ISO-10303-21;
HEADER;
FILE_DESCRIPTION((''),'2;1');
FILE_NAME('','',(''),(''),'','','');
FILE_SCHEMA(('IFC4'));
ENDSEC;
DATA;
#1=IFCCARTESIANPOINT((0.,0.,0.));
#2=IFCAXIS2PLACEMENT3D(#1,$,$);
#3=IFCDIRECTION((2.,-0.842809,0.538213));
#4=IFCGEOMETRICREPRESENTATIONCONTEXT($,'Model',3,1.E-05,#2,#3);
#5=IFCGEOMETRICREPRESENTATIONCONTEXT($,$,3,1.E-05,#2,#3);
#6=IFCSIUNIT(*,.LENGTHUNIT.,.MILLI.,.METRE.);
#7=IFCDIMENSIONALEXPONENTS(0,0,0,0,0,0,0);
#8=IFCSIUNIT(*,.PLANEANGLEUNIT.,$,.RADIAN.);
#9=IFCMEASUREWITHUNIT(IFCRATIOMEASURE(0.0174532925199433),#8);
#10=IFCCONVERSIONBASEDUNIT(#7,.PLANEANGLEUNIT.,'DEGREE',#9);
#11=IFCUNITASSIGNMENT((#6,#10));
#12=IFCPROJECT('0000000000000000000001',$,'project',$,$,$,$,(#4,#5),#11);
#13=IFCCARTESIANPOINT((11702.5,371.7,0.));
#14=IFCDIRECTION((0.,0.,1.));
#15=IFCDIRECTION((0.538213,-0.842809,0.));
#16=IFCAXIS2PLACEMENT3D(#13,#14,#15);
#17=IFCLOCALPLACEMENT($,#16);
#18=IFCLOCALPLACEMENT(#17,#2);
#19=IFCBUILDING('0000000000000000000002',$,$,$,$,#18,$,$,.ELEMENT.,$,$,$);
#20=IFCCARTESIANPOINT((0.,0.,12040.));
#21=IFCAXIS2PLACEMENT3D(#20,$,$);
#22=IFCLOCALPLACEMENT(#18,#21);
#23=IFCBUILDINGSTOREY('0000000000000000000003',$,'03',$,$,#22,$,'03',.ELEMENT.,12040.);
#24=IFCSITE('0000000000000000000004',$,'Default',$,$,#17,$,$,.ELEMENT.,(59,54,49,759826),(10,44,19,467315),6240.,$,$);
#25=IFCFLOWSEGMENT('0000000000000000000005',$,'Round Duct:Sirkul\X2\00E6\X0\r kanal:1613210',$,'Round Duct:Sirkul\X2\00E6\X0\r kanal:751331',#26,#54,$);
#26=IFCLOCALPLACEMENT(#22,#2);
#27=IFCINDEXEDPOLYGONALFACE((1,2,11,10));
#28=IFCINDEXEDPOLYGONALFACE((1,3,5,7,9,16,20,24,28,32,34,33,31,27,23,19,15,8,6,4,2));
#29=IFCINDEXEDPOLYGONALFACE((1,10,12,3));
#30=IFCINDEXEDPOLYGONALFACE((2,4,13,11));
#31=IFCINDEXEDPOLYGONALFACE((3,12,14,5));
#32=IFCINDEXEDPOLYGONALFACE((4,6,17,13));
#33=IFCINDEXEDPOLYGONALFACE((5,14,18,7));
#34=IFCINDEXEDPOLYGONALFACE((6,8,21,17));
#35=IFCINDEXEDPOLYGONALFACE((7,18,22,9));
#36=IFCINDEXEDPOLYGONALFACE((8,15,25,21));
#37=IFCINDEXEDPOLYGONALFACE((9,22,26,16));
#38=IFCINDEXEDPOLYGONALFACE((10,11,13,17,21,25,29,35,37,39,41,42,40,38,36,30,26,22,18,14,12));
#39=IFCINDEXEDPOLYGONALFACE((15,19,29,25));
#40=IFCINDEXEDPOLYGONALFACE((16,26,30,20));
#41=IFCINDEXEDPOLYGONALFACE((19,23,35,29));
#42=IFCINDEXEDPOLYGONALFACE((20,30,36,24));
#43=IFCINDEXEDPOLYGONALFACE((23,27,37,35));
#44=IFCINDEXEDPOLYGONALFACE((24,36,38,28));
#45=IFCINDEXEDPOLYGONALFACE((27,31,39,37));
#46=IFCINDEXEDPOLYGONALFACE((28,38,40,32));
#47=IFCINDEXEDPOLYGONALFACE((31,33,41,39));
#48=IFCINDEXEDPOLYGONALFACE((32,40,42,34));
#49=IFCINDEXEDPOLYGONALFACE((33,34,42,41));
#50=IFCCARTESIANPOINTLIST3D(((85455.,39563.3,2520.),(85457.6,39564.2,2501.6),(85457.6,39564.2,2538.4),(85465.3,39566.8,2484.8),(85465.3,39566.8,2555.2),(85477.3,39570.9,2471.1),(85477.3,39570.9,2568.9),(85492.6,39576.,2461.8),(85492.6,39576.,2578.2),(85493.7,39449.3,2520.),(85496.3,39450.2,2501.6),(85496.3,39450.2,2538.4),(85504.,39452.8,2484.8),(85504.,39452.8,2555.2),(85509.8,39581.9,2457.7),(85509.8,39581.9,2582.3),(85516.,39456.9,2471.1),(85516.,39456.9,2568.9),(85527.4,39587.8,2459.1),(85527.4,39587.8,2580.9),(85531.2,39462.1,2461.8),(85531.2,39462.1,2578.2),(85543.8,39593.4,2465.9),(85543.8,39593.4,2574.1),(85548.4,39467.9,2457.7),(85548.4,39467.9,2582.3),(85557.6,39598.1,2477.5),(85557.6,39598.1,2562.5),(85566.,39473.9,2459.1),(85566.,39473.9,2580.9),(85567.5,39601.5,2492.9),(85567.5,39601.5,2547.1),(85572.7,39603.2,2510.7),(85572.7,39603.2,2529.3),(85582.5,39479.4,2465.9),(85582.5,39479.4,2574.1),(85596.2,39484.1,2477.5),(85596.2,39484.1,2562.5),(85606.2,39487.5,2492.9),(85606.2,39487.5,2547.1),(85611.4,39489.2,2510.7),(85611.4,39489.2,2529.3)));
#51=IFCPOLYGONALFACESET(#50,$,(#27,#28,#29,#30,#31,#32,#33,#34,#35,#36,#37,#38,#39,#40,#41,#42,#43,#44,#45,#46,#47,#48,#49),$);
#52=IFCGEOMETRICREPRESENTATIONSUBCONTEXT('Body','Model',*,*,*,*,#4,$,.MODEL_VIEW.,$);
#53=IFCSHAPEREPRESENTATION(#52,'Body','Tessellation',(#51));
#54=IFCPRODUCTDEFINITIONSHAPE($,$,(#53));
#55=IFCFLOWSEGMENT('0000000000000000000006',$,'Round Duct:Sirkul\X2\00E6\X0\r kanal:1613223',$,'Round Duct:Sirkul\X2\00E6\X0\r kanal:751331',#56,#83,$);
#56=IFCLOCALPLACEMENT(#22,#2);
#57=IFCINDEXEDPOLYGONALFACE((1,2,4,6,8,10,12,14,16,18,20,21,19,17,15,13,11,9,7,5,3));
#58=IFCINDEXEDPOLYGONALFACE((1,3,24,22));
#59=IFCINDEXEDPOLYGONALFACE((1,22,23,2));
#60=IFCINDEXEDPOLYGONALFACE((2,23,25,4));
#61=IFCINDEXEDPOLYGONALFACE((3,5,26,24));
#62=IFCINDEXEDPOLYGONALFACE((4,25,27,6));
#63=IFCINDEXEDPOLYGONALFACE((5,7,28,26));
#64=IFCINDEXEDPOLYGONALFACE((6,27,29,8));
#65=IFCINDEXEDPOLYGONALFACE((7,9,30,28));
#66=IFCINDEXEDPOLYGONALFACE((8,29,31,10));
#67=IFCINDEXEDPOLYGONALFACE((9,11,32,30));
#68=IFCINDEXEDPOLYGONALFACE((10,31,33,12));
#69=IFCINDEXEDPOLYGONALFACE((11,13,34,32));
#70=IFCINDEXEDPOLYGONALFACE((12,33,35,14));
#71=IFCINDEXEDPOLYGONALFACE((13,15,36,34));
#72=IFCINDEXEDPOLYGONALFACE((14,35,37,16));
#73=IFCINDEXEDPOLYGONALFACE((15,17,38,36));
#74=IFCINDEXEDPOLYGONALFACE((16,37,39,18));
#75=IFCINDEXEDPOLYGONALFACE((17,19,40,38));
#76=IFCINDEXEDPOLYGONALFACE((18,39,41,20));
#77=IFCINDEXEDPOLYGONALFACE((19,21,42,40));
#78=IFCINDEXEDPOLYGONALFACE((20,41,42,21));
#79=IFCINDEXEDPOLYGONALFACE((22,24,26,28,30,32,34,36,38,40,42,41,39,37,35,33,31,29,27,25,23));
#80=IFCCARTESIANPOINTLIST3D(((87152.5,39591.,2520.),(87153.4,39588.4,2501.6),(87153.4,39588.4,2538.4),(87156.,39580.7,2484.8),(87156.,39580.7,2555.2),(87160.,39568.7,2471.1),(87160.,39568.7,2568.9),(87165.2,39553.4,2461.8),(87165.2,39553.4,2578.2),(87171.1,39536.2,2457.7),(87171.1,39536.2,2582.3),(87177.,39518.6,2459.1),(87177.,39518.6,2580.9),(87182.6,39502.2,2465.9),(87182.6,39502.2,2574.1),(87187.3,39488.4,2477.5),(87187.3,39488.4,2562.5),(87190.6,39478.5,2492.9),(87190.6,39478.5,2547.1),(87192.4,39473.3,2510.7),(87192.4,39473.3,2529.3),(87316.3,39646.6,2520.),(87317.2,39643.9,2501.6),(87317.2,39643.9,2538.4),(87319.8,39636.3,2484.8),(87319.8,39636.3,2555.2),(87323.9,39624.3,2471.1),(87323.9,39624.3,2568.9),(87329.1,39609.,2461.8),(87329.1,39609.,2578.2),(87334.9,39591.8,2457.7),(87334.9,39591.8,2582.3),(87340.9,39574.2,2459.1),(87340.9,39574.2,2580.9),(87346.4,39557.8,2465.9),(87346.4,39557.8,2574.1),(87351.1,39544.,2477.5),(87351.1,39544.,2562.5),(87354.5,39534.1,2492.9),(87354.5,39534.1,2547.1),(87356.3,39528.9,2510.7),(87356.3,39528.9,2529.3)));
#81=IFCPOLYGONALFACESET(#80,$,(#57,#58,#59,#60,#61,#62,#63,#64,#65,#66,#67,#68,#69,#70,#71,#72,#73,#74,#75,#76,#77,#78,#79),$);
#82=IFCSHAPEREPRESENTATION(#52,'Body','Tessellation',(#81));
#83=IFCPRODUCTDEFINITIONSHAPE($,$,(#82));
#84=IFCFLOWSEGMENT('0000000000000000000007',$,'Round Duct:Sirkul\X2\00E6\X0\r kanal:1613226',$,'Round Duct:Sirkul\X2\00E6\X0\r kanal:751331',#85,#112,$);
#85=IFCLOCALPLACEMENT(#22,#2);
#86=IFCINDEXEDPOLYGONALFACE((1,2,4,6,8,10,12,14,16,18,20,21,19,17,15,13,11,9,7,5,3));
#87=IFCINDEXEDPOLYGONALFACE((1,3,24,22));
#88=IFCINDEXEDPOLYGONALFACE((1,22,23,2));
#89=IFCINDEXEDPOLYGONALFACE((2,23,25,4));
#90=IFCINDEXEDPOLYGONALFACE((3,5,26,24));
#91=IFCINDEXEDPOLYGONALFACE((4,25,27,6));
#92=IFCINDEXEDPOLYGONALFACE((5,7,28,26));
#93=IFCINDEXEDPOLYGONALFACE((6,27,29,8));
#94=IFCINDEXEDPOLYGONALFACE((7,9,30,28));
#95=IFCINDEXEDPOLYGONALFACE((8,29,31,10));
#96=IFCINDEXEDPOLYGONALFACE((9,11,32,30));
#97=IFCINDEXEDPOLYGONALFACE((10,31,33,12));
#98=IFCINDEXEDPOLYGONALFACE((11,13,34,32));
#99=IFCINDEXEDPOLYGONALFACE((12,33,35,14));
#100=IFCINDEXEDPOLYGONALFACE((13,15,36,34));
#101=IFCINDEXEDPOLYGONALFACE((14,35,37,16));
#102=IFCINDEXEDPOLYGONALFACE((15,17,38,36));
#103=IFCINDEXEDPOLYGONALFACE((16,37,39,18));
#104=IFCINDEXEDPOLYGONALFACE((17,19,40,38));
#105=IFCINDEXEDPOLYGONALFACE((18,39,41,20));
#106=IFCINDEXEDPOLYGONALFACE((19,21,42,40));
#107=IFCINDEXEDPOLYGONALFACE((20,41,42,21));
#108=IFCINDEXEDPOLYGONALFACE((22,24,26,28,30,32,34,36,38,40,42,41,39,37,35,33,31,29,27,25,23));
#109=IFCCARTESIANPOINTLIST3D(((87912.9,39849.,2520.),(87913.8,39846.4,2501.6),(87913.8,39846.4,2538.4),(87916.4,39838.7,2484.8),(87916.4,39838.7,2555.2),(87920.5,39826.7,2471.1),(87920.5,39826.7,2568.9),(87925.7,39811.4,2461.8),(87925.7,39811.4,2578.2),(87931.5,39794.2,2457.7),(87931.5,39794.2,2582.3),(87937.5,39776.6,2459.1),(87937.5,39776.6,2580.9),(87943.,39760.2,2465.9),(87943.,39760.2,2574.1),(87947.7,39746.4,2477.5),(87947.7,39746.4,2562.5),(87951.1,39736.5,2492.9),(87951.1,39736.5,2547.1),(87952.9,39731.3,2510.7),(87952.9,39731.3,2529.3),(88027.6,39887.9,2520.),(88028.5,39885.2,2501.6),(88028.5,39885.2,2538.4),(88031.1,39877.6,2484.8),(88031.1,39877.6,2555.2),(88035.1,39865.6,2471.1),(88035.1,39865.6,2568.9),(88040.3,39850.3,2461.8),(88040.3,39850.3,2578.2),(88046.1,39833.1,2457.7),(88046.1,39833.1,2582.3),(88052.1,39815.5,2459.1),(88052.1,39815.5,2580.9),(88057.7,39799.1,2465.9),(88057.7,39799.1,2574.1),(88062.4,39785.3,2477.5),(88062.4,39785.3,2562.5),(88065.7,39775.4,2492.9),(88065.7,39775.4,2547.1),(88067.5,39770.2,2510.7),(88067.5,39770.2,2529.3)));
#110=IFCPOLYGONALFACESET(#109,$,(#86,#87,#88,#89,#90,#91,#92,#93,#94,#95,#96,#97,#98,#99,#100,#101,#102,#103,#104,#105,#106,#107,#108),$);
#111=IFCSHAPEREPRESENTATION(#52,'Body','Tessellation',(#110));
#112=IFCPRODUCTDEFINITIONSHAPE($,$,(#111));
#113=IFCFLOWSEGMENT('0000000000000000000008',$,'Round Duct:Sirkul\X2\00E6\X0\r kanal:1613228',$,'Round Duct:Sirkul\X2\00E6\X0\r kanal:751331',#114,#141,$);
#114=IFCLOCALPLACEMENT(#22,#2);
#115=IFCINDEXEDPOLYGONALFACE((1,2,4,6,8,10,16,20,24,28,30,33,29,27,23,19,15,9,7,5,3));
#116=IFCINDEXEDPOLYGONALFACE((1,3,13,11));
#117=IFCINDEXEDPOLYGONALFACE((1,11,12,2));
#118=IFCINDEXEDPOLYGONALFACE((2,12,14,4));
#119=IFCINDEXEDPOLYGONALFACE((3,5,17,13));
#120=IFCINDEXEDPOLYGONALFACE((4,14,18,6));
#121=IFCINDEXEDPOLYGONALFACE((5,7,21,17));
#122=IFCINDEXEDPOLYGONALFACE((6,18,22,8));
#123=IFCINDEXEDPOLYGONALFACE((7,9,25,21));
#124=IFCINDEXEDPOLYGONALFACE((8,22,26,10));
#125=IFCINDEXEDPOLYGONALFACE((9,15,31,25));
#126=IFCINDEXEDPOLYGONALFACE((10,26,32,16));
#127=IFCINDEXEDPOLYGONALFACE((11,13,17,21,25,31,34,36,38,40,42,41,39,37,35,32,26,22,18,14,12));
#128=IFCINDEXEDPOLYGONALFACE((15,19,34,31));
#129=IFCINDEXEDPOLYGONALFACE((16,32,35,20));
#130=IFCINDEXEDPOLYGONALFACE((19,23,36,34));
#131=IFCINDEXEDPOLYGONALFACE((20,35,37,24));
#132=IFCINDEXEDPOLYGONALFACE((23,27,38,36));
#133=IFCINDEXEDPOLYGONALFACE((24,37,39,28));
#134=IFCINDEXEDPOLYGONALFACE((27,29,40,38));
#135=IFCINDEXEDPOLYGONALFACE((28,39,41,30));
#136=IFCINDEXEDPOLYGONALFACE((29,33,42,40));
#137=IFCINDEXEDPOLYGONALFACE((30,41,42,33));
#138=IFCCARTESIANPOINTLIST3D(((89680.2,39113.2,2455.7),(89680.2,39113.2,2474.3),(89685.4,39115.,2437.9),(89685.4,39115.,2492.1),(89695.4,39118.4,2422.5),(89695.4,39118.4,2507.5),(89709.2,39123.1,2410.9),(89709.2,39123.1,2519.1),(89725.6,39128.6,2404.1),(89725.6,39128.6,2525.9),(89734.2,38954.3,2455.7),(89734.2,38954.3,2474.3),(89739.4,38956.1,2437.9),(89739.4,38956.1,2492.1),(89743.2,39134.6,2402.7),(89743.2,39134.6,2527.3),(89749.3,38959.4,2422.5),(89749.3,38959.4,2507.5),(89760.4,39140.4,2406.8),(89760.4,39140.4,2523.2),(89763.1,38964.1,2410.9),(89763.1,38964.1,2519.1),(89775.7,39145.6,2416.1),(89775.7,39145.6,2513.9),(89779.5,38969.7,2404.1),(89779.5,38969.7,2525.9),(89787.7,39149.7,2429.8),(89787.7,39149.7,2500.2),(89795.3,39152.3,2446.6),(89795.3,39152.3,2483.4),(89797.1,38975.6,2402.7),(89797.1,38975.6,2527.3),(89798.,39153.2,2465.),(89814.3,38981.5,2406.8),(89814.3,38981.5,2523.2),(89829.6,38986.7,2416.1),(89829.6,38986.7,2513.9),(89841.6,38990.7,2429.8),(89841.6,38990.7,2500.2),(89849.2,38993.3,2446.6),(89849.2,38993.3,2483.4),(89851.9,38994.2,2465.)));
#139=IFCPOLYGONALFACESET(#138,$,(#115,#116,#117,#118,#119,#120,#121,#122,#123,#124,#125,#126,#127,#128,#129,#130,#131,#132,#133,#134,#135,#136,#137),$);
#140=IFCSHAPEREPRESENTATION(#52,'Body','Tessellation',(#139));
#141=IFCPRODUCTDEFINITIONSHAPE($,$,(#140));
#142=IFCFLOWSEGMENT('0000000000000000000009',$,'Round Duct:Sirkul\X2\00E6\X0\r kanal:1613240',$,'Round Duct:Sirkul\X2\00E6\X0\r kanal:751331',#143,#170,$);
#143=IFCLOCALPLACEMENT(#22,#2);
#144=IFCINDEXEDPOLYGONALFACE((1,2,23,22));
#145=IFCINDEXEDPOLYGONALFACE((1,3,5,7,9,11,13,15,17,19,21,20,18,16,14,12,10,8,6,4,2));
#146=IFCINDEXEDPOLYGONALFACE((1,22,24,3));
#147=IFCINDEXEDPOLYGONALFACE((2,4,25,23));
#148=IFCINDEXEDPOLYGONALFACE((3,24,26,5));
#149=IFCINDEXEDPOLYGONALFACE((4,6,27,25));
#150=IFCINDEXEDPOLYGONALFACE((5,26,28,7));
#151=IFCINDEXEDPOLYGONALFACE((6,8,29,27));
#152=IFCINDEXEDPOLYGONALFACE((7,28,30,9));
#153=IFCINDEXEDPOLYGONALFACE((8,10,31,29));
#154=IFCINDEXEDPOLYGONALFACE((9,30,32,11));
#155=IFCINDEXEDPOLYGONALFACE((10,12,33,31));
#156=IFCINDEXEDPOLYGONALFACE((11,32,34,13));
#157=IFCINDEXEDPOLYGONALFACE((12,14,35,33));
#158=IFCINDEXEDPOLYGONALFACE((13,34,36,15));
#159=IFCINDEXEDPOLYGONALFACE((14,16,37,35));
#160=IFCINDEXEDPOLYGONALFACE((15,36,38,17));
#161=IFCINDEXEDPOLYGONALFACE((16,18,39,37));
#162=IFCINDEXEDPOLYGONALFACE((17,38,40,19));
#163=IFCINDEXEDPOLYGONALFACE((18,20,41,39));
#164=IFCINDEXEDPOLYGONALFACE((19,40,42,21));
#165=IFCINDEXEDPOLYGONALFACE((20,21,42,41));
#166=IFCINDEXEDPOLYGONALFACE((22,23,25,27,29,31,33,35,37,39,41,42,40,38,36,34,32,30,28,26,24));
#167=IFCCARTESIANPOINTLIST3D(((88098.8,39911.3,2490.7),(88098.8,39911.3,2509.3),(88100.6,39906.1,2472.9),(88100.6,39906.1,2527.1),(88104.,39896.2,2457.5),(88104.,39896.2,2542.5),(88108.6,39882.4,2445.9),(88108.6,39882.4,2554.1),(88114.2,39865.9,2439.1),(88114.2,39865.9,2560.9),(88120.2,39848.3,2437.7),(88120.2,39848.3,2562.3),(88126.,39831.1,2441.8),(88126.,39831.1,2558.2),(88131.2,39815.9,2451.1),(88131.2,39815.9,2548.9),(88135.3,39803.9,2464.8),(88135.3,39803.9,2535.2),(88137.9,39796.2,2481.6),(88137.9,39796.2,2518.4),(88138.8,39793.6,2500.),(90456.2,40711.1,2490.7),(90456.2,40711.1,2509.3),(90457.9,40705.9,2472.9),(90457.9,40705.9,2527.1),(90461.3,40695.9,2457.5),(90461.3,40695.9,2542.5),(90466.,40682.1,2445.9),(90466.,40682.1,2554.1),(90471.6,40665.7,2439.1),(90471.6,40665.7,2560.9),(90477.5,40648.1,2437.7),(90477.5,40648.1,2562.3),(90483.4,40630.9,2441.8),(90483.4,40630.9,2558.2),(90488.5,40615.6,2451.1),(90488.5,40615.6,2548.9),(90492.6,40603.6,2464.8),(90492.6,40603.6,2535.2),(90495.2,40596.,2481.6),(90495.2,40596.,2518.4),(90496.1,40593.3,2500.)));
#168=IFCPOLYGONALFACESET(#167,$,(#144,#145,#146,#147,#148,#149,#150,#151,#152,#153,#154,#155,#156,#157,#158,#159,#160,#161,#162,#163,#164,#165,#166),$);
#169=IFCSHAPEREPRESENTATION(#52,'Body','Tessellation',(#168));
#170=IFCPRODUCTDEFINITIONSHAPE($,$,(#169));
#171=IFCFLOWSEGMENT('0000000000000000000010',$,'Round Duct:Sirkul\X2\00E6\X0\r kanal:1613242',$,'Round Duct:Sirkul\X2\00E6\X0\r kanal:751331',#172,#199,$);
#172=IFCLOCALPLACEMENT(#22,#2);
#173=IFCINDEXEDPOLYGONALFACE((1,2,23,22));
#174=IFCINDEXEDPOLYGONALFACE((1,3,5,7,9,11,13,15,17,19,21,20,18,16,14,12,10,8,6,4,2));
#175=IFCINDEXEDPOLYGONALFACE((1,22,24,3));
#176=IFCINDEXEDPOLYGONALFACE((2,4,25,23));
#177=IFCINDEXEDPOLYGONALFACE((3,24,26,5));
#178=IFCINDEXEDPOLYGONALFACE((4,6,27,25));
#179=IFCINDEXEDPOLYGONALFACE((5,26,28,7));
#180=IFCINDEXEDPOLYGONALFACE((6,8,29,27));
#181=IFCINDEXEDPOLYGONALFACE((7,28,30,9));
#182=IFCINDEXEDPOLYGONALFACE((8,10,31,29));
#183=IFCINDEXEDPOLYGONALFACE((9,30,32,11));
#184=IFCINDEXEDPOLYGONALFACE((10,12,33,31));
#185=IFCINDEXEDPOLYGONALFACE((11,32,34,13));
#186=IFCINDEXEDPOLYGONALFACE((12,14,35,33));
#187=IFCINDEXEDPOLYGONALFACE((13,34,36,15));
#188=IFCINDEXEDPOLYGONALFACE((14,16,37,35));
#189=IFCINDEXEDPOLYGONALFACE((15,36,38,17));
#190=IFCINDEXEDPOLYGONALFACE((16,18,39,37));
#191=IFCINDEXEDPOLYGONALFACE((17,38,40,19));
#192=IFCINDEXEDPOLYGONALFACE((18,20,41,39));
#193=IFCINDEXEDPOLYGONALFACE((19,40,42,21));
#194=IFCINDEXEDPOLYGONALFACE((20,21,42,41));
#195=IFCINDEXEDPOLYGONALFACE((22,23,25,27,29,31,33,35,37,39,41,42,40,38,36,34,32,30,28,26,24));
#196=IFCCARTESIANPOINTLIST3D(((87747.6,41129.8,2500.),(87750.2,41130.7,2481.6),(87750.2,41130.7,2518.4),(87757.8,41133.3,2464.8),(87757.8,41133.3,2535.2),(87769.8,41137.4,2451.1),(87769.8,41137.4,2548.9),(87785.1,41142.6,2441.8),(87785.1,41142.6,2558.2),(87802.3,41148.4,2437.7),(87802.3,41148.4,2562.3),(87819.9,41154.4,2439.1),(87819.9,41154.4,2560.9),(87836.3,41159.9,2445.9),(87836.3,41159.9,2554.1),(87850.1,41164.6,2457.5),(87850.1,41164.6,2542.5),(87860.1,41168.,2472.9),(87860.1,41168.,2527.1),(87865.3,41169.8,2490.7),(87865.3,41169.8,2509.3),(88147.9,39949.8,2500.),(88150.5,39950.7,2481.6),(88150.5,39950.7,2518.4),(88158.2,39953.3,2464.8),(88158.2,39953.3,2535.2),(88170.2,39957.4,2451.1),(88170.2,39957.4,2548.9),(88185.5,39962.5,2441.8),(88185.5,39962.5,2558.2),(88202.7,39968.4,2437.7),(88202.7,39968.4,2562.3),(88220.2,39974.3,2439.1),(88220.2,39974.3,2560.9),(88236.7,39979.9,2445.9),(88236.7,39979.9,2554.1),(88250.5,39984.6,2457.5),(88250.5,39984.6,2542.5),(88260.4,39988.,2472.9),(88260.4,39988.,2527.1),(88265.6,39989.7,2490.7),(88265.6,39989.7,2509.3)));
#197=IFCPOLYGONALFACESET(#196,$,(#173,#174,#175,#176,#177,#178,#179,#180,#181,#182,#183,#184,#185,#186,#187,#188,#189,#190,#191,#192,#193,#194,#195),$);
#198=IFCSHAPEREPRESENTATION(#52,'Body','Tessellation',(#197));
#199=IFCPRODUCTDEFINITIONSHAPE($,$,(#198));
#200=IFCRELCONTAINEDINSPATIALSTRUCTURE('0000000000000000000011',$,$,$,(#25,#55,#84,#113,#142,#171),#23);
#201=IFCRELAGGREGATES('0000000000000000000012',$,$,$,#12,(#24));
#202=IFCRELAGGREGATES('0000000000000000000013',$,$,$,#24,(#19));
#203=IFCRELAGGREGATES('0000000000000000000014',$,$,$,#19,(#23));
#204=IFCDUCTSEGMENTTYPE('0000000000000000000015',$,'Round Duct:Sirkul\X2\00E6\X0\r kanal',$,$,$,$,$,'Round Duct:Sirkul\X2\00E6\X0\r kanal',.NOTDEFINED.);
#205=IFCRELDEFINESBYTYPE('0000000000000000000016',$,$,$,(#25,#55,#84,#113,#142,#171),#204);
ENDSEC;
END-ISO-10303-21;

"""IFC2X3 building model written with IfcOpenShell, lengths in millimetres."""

from ifc_helpers import new_model, entity, si_unit, converted_unit, direction, frame, frame_2d, origin, origin_2d_with_axis, place, context, subcontext, project, spatial, circle, extrude, type_object, element, save


model = new_model("IFC2X3")

# Units and contexts
model_context = context("Model", 3, precision=1e-05, world=origin(), true_north=direction((2.0, -0.842809, 0.538213)))
context_of_model = context(None, 3, precision=1e-05, world=origin(), true_north=direction((2.0, -0.842809, 0.538213)))
body_context = subcontext(model_context, "Body", "Model", "MODEL_VIEW")
ifc_project = project(units=[si_unit("LENGTHUNIT", "METRE", prefix="MILLI"), converted_unit("PLANEANGLEUNIT", "DEGREE", entity("IfcRatioMeasure", 0.0174532925199433), si_unit("PLANEANGLEUNIT", "RADIAN"), dimensions=[0, 0, 0, 0, 0, 0, 0])], contexts=[model_context, context_of_model])

# Site, building, storey
site_placement = place(None, frame((11702.5, 371.7, 0.0), z_axis=(0.0, 0.0, 1.0), x_axis=(0.538213, -0.842809, 0.0)))
site = spatial("IfcSite", under=ifc_project, at=site_placement, Name="Default", CompositionType="ELEMENT", RefLatitude=(59, 54, 49, 759826), RefLongitude=(10, 44, 19, 467315), RefElevation=6240.0)
building_placement = place(site_placement, origin())
building = spatial("IfcBuilding", under=site, at=building_placement, CompositionType="ELEMENT")
storey_placement = place(building_placement, frame((0.0, 0.0, 12040.0)))
storey = spatial("IfcBuildingStorey", under=building, at=storey_placement, Name="03", LongName="03", CompositionType="ELEMENT", Elevation=12040.0)

# Flow segments
duct_segment_type = type_object("IfcDuctSegmentType", Name="Round Duct:Sirkulær kanal", ElementType="Round Duct:Sirkulær kanal", PredefinedType="NOTDEFINED")
flow_segment_1_placement = place(storey_placement, origin())
element("IfcFlowSegment", 1, at=flow_segment_1_placement, inside=storey, type_object=duct_segment_type, Name="Round Duct:Sirkulær kanal:1613210", ObjectType="Round Duct:Sirkulær kanal:751331", context=body_context, shape_type="SweptSolid", body=[
    extrude(circle(Radius=62.5, at=frame_2d((0.0, 0.0), x_axis=(1.0, 0.0))), frame((85552.9, 39469.4, 2520.0), z_axis=(-0.321274, 0.946986, 0.0), x_axis=(-0.946986, -0.321274, 0.0)), (0.0, 0.0, 1.0), 120.4),
])
flow_segment_2_placement = place(storey_placement, origin())
element("IfcFlowSegment", 2, at=flow_segment_2_placement, inside=storey, type_object=duct_segment_type, Name="Round Duct:Sirkulær kanal:1613223", ObjectType="Round Duct:Sirkulær kanal:751331", context=body_context, shape_type="SweptSolid", body=[
    extrude(circle(Radius=62.5, at=origin_2d_with_axis()), frame((87172.6, 39531.8, 2520.0), z_axis=(0.946986, 0.321274, 0.0), x_axis=(-0.321274, 0.946986, 0.0)), (0.0, 0.0, 1.0), 173.0),
])
flow_segment_3_placement = place(storey_placement, origin())
element("IfcFlowSegment", 3, at=flow_segment_3_placement, inside=storey, type_object=duct_segment_type, Name="Round Duct:Sirkulær kanal:1613226", ObjectType="Round Duct:Sirkulær kanal:751331", context=body_context, shape_type="SweptSolid", body=[
    extrude(circle(Radius=62.5, at=origin_2d_with_axis()), frame((87933.0, 39789.8, 2520.0), z_axis=(0.946986, 0.321274, 0.0), x_axis=(-0.321274, 0.946986, 0.0)), (0.0, 0.0, 1.0), 121.1),
])
flow_segment_4_placement = place(storey_placement, origin())
element("IfcFlowSegment", 4, at=flow_segment_4_placement, inside=storey, type_object=duct_segment_type, Name="Round Duct:Sirkulær kanal:1613228", ObjectType="Round Duct:Sirkulær kanal:751331", context=body_context, shape_type="SweptSolid", body=[
    extrude(circle(Radius=62.5, at=origin_2d_with_axis()), frame((89792.7, 38974.1, 2465.0), z_axis=(-0.321246, 0.946996, 0.0), x_axis=(0.946996, 0.321246, 0.0)), (0.0, 0.0, 1.0), 167.8),
])
flow_segment_5_placement = place(storey_placement, origin())
element("IfcFlowSegment", 5, at=flow_segment_5_placement, inside=storey, type_object=duct_segment_type, Name="Round Duct:Sirkulær kanal:1613240", ObjectType="Round Duct:Sirkulær kanal:751331", context=body_context, shape_type="SweptSolid", body=[
    extrude(circle(Radius=62.5, at=origin_2d_with_axis()), frame((88118.7, 39852.8, 2500.0), z_axis=(0.946986, 0.321274, 0.0), x_axis=(0.321274, -0.946986, 0.0)), (0.0, 0.0, 1.0), 2489.3),
])
flow_segment_6_placement = place(storey_placement, origin())
element("IfcFlowSegment", 6, at=flow_segment_6_placement, inside=storey, type_object=duct_segment_type, Name="Round Duct:Sirkulær kanal:1613242", ObjectType="Round Duct:Sirkulær kanal:751331", context=body_context, shape_type="SweptSolid", body=[
    extrude(circle(Radius=62.5, at=origin_2d_with_axis()), frame((88207.1, 39969.9, 2500.0), z_axis=(-0.321274, 0.946986, 0.0), x_axis=(-0.946986, -0.321274, 0.0)), (0.0, 0.0, 1.0), 1246.1),
])

save(model, "model.ifc")
